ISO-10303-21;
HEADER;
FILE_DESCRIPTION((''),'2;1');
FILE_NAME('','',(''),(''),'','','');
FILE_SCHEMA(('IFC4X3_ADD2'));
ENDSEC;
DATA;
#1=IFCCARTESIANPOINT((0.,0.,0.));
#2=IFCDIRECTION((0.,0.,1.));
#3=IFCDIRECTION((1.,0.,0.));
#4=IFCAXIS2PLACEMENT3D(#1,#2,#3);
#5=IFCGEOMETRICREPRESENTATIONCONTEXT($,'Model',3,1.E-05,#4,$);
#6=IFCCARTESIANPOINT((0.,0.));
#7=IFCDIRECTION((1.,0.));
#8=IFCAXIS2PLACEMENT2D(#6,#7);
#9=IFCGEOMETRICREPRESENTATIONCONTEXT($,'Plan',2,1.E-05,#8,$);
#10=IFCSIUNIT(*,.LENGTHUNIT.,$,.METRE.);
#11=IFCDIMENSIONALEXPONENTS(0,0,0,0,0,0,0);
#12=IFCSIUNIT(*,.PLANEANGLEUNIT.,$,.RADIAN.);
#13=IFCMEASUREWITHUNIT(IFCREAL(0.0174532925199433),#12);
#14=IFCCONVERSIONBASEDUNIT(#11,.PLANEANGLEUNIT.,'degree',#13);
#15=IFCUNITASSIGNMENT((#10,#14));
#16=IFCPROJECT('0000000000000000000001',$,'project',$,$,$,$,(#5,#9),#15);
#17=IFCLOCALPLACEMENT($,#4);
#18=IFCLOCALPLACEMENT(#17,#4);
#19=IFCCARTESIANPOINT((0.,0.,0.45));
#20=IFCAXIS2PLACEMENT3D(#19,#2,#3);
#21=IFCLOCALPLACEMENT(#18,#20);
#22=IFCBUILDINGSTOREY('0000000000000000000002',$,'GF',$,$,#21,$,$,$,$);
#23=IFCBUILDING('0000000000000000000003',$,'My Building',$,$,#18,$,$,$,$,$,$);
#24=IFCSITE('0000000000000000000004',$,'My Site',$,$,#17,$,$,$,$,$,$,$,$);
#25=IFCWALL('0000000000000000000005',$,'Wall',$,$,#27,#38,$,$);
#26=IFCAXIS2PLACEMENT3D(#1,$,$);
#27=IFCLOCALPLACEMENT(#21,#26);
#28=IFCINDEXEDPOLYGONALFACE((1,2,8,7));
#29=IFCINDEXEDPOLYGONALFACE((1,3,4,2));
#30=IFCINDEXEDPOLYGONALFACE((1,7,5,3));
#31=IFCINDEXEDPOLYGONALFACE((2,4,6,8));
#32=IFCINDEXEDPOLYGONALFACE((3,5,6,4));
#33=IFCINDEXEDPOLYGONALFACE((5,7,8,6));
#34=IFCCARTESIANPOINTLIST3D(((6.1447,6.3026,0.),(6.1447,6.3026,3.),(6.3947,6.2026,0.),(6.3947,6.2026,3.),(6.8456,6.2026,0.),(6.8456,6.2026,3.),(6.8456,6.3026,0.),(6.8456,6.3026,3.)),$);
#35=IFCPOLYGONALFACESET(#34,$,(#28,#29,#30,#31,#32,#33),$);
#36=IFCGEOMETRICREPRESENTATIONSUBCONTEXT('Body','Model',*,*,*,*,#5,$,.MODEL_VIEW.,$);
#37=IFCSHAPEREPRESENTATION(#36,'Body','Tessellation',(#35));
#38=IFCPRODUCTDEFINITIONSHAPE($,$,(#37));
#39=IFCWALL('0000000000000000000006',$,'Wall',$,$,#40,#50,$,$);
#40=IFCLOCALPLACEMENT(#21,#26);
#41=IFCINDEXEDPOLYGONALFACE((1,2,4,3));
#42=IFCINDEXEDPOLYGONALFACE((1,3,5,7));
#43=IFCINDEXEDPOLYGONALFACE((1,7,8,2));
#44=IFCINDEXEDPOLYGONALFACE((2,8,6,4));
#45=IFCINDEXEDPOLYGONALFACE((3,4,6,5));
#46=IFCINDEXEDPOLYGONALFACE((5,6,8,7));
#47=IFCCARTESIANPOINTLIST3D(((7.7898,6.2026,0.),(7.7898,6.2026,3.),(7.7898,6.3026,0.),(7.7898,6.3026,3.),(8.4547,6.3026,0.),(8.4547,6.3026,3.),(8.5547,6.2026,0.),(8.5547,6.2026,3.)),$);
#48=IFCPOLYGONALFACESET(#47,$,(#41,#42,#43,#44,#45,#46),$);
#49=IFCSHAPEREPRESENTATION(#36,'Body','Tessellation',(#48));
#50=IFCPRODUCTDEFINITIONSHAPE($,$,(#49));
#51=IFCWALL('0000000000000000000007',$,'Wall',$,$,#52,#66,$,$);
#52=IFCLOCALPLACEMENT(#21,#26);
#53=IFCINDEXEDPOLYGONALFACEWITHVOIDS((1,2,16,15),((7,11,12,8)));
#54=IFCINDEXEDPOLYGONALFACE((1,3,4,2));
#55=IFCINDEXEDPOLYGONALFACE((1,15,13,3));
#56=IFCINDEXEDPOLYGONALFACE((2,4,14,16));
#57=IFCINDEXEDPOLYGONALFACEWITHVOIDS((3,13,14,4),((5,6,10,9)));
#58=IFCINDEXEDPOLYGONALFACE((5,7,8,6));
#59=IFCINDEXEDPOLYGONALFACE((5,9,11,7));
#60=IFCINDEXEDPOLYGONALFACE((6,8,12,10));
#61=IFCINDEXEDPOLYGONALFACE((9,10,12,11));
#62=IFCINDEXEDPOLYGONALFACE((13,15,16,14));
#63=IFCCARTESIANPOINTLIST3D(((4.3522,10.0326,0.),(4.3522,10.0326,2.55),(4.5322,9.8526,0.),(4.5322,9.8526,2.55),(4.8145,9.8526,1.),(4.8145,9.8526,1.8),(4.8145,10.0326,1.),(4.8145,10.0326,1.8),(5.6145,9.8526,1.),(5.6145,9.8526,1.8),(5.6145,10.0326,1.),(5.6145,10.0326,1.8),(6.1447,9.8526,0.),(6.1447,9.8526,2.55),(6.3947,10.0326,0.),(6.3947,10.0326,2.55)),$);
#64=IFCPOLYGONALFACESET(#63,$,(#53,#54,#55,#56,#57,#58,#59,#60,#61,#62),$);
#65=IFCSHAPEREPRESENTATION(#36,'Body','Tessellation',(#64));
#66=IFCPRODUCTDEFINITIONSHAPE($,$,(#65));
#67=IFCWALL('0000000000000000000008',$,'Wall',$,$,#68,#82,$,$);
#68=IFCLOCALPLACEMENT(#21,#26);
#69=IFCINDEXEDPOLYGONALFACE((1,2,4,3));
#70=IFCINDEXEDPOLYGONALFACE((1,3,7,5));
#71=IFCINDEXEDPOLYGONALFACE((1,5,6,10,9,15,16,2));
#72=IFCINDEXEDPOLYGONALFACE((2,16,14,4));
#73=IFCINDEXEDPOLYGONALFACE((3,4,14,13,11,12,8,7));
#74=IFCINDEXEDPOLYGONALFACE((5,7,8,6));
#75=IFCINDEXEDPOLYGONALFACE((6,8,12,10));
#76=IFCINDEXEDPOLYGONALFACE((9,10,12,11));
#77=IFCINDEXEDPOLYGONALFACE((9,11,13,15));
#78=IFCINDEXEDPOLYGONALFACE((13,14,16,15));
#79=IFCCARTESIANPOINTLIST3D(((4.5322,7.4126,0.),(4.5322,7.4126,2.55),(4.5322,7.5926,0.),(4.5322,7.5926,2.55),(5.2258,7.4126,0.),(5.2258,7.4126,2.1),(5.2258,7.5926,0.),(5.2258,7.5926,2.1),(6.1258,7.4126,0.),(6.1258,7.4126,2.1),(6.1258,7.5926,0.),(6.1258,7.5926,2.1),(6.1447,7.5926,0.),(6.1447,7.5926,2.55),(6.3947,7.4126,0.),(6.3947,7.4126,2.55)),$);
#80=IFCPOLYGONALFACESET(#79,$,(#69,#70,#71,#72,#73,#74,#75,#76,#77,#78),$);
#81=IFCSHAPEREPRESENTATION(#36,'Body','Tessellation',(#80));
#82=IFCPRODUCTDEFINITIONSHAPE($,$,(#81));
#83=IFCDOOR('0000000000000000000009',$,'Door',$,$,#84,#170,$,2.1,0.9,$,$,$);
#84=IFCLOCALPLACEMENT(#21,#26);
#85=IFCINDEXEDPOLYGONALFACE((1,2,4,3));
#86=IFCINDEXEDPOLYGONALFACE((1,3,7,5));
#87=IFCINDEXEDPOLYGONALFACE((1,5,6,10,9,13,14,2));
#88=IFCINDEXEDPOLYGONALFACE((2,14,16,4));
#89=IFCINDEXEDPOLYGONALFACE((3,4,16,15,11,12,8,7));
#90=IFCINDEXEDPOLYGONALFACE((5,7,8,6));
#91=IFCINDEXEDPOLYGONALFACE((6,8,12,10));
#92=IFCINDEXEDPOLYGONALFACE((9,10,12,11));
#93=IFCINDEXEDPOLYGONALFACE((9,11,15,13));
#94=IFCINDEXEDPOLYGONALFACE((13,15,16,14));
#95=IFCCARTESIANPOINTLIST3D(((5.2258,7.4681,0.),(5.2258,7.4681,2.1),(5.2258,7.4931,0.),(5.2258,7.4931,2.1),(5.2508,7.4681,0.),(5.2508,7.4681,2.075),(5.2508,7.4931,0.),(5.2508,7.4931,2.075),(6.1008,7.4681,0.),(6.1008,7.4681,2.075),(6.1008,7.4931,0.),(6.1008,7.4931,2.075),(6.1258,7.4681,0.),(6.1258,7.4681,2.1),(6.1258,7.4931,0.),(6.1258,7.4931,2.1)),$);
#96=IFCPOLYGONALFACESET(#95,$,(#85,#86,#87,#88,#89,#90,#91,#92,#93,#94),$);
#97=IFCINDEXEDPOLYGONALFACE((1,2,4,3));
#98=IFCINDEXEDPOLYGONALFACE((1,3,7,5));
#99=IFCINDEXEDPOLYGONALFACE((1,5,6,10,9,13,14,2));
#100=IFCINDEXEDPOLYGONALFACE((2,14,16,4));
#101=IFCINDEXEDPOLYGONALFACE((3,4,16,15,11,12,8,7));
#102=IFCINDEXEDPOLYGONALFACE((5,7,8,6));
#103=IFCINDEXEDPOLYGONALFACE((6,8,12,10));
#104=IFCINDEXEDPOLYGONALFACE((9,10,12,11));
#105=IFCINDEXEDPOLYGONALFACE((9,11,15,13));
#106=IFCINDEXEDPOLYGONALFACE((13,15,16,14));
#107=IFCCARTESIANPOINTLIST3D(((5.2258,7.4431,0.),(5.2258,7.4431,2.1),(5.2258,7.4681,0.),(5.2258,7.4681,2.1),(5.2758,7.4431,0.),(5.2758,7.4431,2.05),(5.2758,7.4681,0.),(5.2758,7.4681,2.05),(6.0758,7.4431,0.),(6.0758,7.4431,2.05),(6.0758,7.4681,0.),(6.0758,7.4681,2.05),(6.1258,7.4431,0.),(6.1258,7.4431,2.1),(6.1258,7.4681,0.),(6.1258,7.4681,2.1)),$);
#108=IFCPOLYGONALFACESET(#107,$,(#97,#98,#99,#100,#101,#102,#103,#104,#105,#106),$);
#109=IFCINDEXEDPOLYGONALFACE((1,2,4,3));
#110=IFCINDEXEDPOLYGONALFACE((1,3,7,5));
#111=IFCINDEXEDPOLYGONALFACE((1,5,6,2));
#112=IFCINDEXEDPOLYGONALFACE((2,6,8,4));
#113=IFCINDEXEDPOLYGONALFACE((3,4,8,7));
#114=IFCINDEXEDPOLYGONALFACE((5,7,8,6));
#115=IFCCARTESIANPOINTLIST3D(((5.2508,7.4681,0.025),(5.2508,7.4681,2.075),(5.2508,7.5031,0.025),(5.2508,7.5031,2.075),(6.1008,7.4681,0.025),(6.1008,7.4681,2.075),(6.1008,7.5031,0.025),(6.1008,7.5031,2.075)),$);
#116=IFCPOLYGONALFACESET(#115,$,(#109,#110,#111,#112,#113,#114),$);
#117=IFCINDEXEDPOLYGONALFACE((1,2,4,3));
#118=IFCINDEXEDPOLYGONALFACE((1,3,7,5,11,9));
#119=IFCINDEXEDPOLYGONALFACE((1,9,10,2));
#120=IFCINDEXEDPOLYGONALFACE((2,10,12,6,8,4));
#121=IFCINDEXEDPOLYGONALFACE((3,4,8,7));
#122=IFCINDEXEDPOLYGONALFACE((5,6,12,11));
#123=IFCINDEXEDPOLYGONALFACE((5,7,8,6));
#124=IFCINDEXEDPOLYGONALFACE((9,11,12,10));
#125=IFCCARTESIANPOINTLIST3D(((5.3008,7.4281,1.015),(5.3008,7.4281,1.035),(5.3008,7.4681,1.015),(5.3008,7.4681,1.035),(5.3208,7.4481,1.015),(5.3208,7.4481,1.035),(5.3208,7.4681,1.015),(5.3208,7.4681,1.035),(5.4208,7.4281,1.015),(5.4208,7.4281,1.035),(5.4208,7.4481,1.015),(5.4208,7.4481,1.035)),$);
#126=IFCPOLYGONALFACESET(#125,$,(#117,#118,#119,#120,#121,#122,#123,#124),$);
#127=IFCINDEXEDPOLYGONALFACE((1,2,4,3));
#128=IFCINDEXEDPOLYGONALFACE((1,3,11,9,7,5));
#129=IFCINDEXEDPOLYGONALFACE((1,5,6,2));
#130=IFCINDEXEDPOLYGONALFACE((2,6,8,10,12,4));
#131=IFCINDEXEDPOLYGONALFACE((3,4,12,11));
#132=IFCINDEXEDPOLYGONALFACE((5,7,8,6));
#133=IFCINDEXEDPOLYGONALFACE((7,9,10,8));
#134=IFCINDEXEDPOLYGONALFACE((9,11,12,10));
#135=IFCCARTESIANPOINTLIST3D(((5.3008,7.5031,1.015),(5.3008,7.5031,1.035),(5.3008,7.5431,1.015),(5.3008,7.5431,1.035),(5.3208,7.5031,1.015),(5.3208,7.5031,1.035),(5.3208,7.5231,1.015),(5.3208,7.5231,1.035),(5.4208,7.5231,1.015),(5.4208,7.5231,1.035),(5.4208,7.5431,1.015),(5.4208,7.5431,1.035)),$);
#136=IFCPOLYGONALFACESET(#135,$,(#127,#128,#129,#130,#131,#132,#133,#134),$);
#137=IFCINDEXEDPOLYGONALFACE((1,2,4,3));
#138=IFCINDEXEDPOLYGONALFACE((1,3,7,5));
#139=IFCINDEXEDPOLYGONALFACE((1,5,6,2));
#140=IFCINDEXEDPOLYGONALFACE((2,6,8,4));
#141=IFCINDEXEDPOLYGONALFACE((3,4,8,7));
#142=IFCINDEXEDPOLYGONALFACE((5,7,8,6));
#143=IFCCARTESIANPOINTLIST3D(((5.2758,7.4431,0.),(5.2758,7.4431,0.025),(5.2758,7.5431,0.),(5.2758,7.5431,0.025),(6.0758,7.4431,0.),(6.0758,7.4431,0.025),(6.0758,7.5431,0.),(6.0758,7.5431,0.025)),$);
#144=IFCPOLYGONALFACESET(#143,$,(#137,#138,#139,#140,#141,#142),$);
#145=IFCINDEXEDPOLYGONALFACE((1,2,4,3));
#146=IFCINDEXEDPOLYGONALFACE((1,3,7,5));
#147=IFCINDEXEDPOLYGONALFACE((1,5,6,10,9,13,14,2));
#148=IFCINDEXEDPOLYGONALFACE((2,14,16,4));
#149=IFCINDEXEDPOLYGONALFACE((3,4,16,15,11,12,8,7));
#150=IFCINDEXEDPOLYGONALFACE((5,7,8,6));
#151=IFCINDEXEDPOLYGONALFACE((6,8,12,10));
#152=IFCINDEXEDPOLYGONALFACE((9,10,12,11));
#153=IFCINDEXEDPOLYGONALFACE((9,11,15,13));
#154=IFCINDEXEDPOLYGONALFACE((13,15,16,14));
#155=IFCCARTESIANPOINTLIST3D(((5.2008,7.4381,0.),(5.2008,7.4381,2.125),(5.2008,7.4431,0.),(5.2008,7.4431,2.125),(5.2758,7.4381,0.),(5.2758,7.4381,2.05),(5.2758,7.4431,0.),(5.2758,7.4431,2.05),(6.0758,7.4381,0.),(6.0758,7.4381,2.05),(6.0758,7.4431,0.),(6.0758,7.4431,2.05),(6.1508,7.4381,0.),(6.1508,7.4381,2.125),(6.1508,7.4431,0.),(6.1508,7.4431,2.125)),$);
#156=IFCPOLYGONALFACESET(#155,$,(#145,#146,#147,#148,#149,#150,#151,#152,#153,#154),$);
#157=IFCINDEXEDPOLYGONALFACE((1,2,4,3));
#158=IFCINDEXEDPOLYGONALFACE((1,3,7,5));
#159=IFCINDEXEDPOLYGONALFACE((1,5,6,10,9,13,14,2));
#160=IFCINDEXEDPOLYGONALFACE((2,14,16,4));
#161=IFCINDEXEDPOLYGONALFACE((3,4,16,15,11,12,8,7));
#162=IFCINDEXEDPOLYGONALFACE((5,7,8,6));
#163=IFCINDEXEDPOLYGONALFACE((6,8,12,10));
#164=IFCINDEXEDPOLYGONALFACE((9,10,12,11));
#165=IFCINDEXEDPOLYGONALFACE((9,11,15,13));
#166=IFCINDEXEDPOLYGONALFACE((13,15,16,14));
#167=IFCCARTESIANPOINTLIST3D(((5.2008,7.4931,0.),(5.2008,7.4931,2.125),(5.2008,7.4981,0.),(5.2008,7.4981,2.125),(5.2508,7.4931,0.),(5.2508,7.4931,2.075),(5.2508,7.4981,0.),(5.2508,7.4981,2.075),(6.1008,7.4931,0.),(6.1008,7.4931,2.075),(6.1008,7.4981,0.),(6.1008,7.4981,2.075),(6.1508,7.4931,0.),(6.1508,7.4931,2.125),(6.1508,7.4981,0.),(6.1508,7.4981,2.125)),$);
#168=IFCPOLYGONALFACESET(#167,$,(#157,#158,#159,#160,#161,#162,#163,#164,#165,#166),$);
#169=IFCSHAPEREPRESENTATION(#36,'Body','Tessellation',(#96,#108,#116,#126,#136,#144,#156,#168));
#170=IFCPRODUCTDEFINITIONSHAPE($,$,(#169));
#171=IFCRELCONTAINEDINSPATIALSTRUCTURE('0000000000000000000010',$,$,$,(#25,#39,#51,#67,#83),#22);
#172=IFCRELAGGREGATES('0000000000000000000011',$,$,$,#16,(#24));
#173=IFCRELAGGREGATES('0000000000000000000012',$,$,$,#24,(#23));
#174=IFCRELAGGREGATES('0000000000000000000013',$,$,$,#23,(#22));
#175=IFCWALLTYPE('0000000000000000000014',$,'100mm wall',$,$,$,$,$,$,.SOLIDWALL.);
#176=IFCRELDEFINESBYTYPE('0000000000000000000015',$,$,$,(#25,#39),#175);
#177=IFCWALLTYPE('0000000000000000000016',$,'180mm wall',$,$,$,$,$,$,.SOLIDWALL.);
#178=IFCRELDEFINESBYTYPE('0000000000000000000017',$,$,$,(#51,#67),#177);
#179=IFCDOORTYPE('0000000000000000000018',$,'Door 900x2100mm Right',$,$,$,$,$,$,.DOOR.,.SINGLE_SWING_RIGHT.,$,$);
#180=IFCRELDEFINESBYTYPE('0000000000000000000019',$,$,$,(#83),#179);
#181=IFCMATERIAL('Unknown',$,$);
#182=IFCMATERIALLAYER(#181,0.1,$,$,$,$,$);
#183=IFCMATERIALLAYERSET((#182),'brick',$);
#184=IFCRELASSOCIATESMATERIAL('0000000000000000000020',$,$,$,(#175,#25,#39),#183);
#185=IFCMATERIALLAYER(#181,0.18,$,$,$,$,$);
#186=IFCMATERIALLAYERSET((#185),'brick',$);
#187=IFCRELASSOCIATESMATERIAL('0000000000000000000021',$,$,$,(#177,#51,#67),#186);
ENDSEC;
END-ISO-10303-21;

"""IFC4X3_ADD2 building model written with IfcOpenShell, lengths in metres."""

from ifc_helpers import new_model, entity, si_unit, converted_unit, frame, origin_with_axes, origin_2d_with_axis, place, context, subcontext, project, spatial, line, indexed_curve, outline, extrude, shape, source, transform, mapped, material, layer, layer_set, layer_usage, type_object, type_shapes, element, fill, save


model = new_model("IFC4X3_ADD2")

# Units and contexts
model_context = context("Model", 3, precision=1e-05, world=origin_with_axes())
plan_context = context("Plan", 2, precision=1e-05, world=origin_2d_with_axis())
body_context_1 = subcontext(model_context, "Body", "Model", "MODEL_VIEW")
body_context_2 = subcontext(plan_context, "Body", "Plan", "PLAN_VIEW")
ifc_project = project(units=[si_unit("LENGTHUNIT", "METRE"), converted_unit("PLANEANGLEUNIT", "degree", entity("IfcReal", 0.0174532925199433), si_unit("PLANEANGLEUNIT", "RADIAN"), dimensions=[0, 0, 0, 0, 0, 0, 0])], contexts=[model_context, plan_context])

# Site, building, storey
site_placement = place(None, origin_with_axes())
site = spatial("IfcSite", under=ifc_project, at=site_placement, Name="My Site")
building_placement = place(site_placement, origin_with_axes())
building = spatial("IfcBuilding", under=site, at=building_placement, Name="My Building")
storey_placement = place(building_placement, frame((0.0, 0.0, 0.45), z_axis=(0.0, 0.0, 1.0), x_axis=(1.0, 0.0, 0.0)))
storey = spatial("IfcBuildingStorey", under=building, at=storey_placement, Name="GF")

# Shared definitions
ifc_material_1 = material(Name="Unknown")

# Walls
ifc_layer_1 = layer(ifc_material_1, 0.1)
ifc_layer_set_1 = layer_set([ifc_layer_1], Name="brick")
ifc_layer_usage_1 = layer_usage(ifc_layer_set_1, "AXIS2", "POSITIVE", 0.0)
wall_type_1 = type_object("IfcWallType", Name="100mm wall", PredefinedType="SOLIDWALL", material=ifc_layer_set_1)
wall_1_placement = place(storey_placement, frame((6.3947, 6.2026, 0.0), z_axis=(0.0, 0.0, 1.0), x_axis=(1.0, 0.0, 0.0)))
element("IfcWall", 1, at=wall_1_placement, inside=storey, type_object=wall_type_1, material=ifc_layer_usage_1, Name="Wall", context=body_context_1, shape_type="SweptSolid", body=[
    extrude(outline(indexed_curve([(0.0, 0.0), (-0.25, 0.1), (0.451, 0.1), (0.451, 0.0)], segments=[line(1, 2, 3, 4, 1)])), origin_with_axes(), (0.0, 0.0, 1.0), 3.0),
])
ifc_layer_usage_2 = layer_usage(ifc_layer_set_1, "AXIS2", "POSITIVE", 0.0)
wall_2_placement = place(storey_placement, frame((7.7898, 6.2026, 0.0), z_axis=(0.0, 0.0, 1.0), x_axis=(1.0, 0.0, 0.0)))
element("IfcWall", 2, at=wall_2_placement, inside=storey, type_object=wall_type_1, material=ifc_layer_usage_2, Name="Wall", context=body_context_1, shape_type="SweptSolid", body=[
    extrude(outline(indexed_curve([(0.0, 0.0), (0.0, 0.1), (0.6649, 0.1), (0.7649, 0.0)], segments=[line(1, 2, 3, 4, 1)])), origin_with_axes(), (0.0, 0.0, 1.0), 3.0),
])

# Wall, opening
ifc_layer_2 = layer(ifc_material_1, 0.18)
ifc_layer_set_2 = layer_set([ifc_layer_2], Name="brick")
ifc_layer_usage_3 = layer_usage(ifc_layer_set_2, "AXIS2", "POSITIVE", 0.0)
wall_type_2 = type_object("IfcWallType", Name="180mm wall", PredefinedType="SOLIDWALL", material=ifc_layer_set_2)
wall_3_placement = place(storey_placement, frame((6.3947, 10.0326, 0.0), z_axis=(0.0, 0.0, 1.0), x_axis=(-1.0, 0.0, 0.0)))
wall_3 = element("IfcWall", 3, at=wall_3_placement, inside=storey, type_object=wall_type_2, material=ifc_layer_usage_3, Name="Wall", context=body_context_1, shape_type="SweptSolid", body=[
    extrude(outline(indexed_curve([(0.0, 0.0), (0.25, 0.18), (1.8625, 0.18), (2.0425, 0.0)], segments=[line(1, 2, 3, 4, 1)])), origin_with_axes(), (0.0, 0.0, 1.0), 2.55),
])
shared_shape_1 = source(origin_with_axes(), body_context_1, "Body", "SweptSolid", [
    extrude(outline(indexed_curve([(0.0, 0.0), (0.8, 0.0), (0.8, 0.8), (0.0, 0.8)], segments=[line(1, 2, 3, 4, 1)])), frame((-0.4, -0.6, 0.0), z_axis=(0.0, -1.0, 0.0), x_axis=(1.0, 0.0, 0.0)), (0.0, 0.0, -1.0), 1.2),
])
opening_1_placement = place(wall_3_placement, frame((1.1802, 0.0422, 1.0), z_axis=(0.0, 0.0, 1.0), x_axis=(1.0, 0.0, 0.0)))
element("IfcOpeningElement", 4, at=opening_1_placement, cuts=wall_3, PredefinedType="OPENING", context=body_context_1, shape_type="MappedRepresentation", body=[
    mapped(shared_shape_1, transform((0.0, 0.0, 0.0), x_axis=(1.0, 0.0, 0.0), y_axis=(0.0, 1.0, 0.0), z_axis=(0.0, 0.0, 1.0), scale=1.0)),
])

# Wall, opening, door
ifc_layer_usage_4 = layer_usage(ifc_layer_set_2, "AXIS2", "POSITIVE", 0.0)
wall_4_placement = place(storey_placement, frame((6.3947, 7.5926, 0.0), z_axis=(0.0, 0.0, 1.0), x_axis=(-1.0, 0.0, 0.0)))
wall_4 = element("IfcWall", 5, at=wall_4_placement, inside=storey, type_object=wall_type_2, material=ifc_layer_usage_4, Name="Wall", context=body_context_1, shape_type="SweptSolid", body=[
    extrude(outline(indexed_curve([(0.25, 0.0), (0.0, 0.18), (1.8625, 0.18), (1.8625, 0.0)], segments=[line(1, 2, 3, 4, 1)])), origin_with_axes(), (0.0, 0.0, 1.0), 2.55),
])
shared_shape_2 = source(origin_with_axes(), body_context_1, "Body", "SolidModel", [
    extrude(outline(indexed_curve([(0.0, 0.0), (0.9, 0.0), (0.9, 2.1), (0.0, 2.1)], segments=[line(1, 2, 3, 4, 1)])), frame((0.0, -0.6, 0.0), z_axis=(0.0, -1.0, 0.0), x_axis=(1.0, 0.0, 0.0)), (0.0, 0.0, -1.0), 1.2),
])
opening_2_placement = place(wall_4_placement, frame((1.1688, 0.1495, 0.0), z_axis=(0.0, 0.0, 1.0), x_axis=(-1.0, 0.0, 0.0)))
opening_2 = element("IfcOpeningElement", 6, at=opening_2_placement, cuts=wall_4, PredefinedType="OPENING", context=body_context_1, shape_type="MappedRepresentation", body=[
    mapped(shared_shape_2, transform((0.0, 0.0, 0.0), x_axis=(1.0, 0.0, 0.0), y_axis=(0.0, 1.0, 0.0), z_axis=(0.0, 0.0, 1.0), scale=1.0)),
])
door_type = type_object("IfcDoorType", Name="Door 900x2100mm Right", OperationType="SINGLE_SWING_RIGHT", PredefinedType="DOOR")
shared_shape_3 = source(origin_with_axes(), body_context_1, "Body", "SweptSolid", [
    extrude(outline(indexed_curve([(0.0, 0.0), (0.0, 2.1), (0.9, 2.1), (0.9, 0.0), (0.875, 0.0), (0.875, 2.075), (0.025, 2.075), (0.025, 0.0)], segments=[line(1, 2, 3, 4, 5, 6, 7, 8, 1)])), frame((0.0, 0.025, 0.0), z_axis=(0.0, -1.0, 0.0), x_axis=(1.0, 0.0, 0.0)), (0.0, 0.0, -1.0), 0.025),
    extrude(outline(indexed_curve([(0.0, 0.0), (0.0, 2.1), (0.9, 2.1), (0.9, 0.0), (0.85, 0.0), (0.85, 2.05), (0.05, 2.05), (0.05, 0.0)], segments=[line(1, 2, 3, 4, 5, 6, 7, 8, 1)])), frame((0.0, 0.0, 0.0), z_axis=(0.0, -1.0, 0.0), x_axis=(1.0, 0.0, 0.0)), (0.0, 0.0, -1.0), 0.025),
    extrude(outline(indexed_curve([(0.0, 0.0), (0.85, 0.0), (0.85, 0.035), (0.0, 0.035)], segments=[line(1, 2, 3, 4, 1)])), frame((0.025, 0.025, 0.025), z_axis=(0.0, 0.0, 1.0), x_axis=(1.0, 0.0, 0.0)), (0.0, 0.0, 1.0), 2.05),
    extrude(outline(indexed_curve([(0.0, 0.0), (0.0, -0.04), (0.12, -0.04), (0.12, -0.02), (0.02, -0.02), (0.02, 0.0)], segments=[line(1, 2, 3, 4, 5, 6, 1)])), frame((0.075, 0.025, 1.015), z_axis=(0.0, 0.0, 1.0), x_axis=(1.0, 0.0, 0.0)), (0.0, 0.0, 1.0), 0.02),
    extrude(outline(indexed_curve([(0.0, 0.0), (0.0, 0.04), (0.12, 0.04), (0.12, 0.02), (0.02, 0.02), (0.02, 0.0)], segments=[line(1, 2, 3, 4, 5, 6, 1)])), frame((0.075, 0.06, 1.015), z_axis=(0.0, 0.0, 1.0), x_axis=(1.0, 0.0, 0.0)), (0.0, 0.0, 1.0), 0.02),
    extrude(outline(indexed_curve([(0.0, 0.0), (0.8, 0.0), (0.8, 0.1), (0.0, 0.1)], segments=[line(1, 2, 3, 4, 1)])), frame((0.05, 0.0, 0.0), z_axis=(0.0, 0.0, 1.0), x_axis=(1.0, 0.0, 0.0)), (0.0, 0.0, 1.0), 0.025),
    extrude(outline(indexed_curve([(0.0, 0.0), (0.0, 2.125), (0.95, 2.125), (0.95, 0.0), (0.875, 0.0), (0.875, 2.05), (0.075, 2.05), (0.075, 0.0)], segments=[line(1, 2, 3, 4, 5, 6, 7, 8, 1)])), frame((-0.025, -0.005, 0.0), z_axis=(0.0, -1.0, 0.0), x_axis=(1.0, 0.0, 0.0)), (0.0, 0.0, -1.0), 0.005),
    extrude(outline(indexed_curve([(0.0, 0.0), (0.0, 2.125), (0.95, 2.125), (0.95, 0.0), (0.9, 0.0), (0.9, 2.075), (0.05, 2.075), (0.05, 0.0)], segments=[line(1, 2, 3, 4, 5, 6, 7, 8, 1)])), frame((-0.025, 0.05, 0.0), z_axis=(0.0, -1.0, 0.0), x_axis=(1.0, 0.0, 0.0)), (0.0, 0.0, -1.0), 0.005),
])
shared_shape_4 = source(origin_with_axes(), body_context_2, "Body", "Curve2D", [
    entity("IfcIndexedPolyCurve", entity("IfcCartesianPointList2D", [[0.0, 0.0], [0.0, 0.05], [0.025, 0.05], [0.025, 0.025], [0.05, 0.025], [0.05, 0.0]]), [entity("IfcLineIndex", [1, 2, 3, 4, 5, 6, 1])]),
    entity("IfcIndexedPolyCurve", entity("IfcCartesianPointList2D", [[0.9, 0.0], [0.9, 0.05], [0.875, 0.05], [0.875, 0.025], [0.85, 0.025], [0.85, 0.0]]), [entity("IfcLineIndex", [1, 2, 3, 4, 5, 6, 1])]),
    entity("IfcTrimmedCurve", entity("IfcEllipse", entity("IfcAxis2Placement2D", entity("IfcCartesianPoint", [0.84, 0.05]), entity("IfcDirection", [1.0, 0.0])), 0.815, 0.85), [entity("IfcCartesianPoint", [0.84, 0.9])], [entity("IfcCartesianPoint", [0.025, 0.05])], True, "CARTESIAN"),
    entity("IfcIndexedPolyCurve", entity("IfcCartesianPointList2D", [[0.875, 0.05], [0.84, 0.05], [0.84, 0.9], [0.875, 0.9]]), [entity("IfcLineIndex", [1, 2, 3, 4, 1])]),
])
type_shapes(door_type, [shared_shape_3, shared_shape_4])
door_placement = place(opening_2_placement, frame((0.0, 0.0, 0.0), z_axis=(0.0, 0.0, 1.0), x_axis=(1.0, 0.0, 0.0)))
door = element("IfcDoor", 7, at=door_placement, inside=storey, type_object=door_type, Name="Door", OverallHeight=2.1, OverallWidth=0.9, shapes=[
    shape(body_context_1, "Body", "MappedRepresentation", [mapped(shared_shape_3, transform((0.0, 0.0, 0.0), x_axis=(1.0, 0.0, 0.0), y_axis=(0.0, 1.0, 0.0), z_axis=(0.0, 0.0, 1.0), scale=1.0))]),
    shape(body_context_2, "Body", "MappedRepresentation", [mapped(shared_shape_4, transform((0.0, 0.0, 0.0), x_axis=(1.0, 0.0, 0.0), y_axis=(0.0, 1.0, 0.0), z_axis=(0.0, 0.0, 1.0), scale=1.0))]),
])
fill(opening_2, door)

save(model, "model.ifc")
